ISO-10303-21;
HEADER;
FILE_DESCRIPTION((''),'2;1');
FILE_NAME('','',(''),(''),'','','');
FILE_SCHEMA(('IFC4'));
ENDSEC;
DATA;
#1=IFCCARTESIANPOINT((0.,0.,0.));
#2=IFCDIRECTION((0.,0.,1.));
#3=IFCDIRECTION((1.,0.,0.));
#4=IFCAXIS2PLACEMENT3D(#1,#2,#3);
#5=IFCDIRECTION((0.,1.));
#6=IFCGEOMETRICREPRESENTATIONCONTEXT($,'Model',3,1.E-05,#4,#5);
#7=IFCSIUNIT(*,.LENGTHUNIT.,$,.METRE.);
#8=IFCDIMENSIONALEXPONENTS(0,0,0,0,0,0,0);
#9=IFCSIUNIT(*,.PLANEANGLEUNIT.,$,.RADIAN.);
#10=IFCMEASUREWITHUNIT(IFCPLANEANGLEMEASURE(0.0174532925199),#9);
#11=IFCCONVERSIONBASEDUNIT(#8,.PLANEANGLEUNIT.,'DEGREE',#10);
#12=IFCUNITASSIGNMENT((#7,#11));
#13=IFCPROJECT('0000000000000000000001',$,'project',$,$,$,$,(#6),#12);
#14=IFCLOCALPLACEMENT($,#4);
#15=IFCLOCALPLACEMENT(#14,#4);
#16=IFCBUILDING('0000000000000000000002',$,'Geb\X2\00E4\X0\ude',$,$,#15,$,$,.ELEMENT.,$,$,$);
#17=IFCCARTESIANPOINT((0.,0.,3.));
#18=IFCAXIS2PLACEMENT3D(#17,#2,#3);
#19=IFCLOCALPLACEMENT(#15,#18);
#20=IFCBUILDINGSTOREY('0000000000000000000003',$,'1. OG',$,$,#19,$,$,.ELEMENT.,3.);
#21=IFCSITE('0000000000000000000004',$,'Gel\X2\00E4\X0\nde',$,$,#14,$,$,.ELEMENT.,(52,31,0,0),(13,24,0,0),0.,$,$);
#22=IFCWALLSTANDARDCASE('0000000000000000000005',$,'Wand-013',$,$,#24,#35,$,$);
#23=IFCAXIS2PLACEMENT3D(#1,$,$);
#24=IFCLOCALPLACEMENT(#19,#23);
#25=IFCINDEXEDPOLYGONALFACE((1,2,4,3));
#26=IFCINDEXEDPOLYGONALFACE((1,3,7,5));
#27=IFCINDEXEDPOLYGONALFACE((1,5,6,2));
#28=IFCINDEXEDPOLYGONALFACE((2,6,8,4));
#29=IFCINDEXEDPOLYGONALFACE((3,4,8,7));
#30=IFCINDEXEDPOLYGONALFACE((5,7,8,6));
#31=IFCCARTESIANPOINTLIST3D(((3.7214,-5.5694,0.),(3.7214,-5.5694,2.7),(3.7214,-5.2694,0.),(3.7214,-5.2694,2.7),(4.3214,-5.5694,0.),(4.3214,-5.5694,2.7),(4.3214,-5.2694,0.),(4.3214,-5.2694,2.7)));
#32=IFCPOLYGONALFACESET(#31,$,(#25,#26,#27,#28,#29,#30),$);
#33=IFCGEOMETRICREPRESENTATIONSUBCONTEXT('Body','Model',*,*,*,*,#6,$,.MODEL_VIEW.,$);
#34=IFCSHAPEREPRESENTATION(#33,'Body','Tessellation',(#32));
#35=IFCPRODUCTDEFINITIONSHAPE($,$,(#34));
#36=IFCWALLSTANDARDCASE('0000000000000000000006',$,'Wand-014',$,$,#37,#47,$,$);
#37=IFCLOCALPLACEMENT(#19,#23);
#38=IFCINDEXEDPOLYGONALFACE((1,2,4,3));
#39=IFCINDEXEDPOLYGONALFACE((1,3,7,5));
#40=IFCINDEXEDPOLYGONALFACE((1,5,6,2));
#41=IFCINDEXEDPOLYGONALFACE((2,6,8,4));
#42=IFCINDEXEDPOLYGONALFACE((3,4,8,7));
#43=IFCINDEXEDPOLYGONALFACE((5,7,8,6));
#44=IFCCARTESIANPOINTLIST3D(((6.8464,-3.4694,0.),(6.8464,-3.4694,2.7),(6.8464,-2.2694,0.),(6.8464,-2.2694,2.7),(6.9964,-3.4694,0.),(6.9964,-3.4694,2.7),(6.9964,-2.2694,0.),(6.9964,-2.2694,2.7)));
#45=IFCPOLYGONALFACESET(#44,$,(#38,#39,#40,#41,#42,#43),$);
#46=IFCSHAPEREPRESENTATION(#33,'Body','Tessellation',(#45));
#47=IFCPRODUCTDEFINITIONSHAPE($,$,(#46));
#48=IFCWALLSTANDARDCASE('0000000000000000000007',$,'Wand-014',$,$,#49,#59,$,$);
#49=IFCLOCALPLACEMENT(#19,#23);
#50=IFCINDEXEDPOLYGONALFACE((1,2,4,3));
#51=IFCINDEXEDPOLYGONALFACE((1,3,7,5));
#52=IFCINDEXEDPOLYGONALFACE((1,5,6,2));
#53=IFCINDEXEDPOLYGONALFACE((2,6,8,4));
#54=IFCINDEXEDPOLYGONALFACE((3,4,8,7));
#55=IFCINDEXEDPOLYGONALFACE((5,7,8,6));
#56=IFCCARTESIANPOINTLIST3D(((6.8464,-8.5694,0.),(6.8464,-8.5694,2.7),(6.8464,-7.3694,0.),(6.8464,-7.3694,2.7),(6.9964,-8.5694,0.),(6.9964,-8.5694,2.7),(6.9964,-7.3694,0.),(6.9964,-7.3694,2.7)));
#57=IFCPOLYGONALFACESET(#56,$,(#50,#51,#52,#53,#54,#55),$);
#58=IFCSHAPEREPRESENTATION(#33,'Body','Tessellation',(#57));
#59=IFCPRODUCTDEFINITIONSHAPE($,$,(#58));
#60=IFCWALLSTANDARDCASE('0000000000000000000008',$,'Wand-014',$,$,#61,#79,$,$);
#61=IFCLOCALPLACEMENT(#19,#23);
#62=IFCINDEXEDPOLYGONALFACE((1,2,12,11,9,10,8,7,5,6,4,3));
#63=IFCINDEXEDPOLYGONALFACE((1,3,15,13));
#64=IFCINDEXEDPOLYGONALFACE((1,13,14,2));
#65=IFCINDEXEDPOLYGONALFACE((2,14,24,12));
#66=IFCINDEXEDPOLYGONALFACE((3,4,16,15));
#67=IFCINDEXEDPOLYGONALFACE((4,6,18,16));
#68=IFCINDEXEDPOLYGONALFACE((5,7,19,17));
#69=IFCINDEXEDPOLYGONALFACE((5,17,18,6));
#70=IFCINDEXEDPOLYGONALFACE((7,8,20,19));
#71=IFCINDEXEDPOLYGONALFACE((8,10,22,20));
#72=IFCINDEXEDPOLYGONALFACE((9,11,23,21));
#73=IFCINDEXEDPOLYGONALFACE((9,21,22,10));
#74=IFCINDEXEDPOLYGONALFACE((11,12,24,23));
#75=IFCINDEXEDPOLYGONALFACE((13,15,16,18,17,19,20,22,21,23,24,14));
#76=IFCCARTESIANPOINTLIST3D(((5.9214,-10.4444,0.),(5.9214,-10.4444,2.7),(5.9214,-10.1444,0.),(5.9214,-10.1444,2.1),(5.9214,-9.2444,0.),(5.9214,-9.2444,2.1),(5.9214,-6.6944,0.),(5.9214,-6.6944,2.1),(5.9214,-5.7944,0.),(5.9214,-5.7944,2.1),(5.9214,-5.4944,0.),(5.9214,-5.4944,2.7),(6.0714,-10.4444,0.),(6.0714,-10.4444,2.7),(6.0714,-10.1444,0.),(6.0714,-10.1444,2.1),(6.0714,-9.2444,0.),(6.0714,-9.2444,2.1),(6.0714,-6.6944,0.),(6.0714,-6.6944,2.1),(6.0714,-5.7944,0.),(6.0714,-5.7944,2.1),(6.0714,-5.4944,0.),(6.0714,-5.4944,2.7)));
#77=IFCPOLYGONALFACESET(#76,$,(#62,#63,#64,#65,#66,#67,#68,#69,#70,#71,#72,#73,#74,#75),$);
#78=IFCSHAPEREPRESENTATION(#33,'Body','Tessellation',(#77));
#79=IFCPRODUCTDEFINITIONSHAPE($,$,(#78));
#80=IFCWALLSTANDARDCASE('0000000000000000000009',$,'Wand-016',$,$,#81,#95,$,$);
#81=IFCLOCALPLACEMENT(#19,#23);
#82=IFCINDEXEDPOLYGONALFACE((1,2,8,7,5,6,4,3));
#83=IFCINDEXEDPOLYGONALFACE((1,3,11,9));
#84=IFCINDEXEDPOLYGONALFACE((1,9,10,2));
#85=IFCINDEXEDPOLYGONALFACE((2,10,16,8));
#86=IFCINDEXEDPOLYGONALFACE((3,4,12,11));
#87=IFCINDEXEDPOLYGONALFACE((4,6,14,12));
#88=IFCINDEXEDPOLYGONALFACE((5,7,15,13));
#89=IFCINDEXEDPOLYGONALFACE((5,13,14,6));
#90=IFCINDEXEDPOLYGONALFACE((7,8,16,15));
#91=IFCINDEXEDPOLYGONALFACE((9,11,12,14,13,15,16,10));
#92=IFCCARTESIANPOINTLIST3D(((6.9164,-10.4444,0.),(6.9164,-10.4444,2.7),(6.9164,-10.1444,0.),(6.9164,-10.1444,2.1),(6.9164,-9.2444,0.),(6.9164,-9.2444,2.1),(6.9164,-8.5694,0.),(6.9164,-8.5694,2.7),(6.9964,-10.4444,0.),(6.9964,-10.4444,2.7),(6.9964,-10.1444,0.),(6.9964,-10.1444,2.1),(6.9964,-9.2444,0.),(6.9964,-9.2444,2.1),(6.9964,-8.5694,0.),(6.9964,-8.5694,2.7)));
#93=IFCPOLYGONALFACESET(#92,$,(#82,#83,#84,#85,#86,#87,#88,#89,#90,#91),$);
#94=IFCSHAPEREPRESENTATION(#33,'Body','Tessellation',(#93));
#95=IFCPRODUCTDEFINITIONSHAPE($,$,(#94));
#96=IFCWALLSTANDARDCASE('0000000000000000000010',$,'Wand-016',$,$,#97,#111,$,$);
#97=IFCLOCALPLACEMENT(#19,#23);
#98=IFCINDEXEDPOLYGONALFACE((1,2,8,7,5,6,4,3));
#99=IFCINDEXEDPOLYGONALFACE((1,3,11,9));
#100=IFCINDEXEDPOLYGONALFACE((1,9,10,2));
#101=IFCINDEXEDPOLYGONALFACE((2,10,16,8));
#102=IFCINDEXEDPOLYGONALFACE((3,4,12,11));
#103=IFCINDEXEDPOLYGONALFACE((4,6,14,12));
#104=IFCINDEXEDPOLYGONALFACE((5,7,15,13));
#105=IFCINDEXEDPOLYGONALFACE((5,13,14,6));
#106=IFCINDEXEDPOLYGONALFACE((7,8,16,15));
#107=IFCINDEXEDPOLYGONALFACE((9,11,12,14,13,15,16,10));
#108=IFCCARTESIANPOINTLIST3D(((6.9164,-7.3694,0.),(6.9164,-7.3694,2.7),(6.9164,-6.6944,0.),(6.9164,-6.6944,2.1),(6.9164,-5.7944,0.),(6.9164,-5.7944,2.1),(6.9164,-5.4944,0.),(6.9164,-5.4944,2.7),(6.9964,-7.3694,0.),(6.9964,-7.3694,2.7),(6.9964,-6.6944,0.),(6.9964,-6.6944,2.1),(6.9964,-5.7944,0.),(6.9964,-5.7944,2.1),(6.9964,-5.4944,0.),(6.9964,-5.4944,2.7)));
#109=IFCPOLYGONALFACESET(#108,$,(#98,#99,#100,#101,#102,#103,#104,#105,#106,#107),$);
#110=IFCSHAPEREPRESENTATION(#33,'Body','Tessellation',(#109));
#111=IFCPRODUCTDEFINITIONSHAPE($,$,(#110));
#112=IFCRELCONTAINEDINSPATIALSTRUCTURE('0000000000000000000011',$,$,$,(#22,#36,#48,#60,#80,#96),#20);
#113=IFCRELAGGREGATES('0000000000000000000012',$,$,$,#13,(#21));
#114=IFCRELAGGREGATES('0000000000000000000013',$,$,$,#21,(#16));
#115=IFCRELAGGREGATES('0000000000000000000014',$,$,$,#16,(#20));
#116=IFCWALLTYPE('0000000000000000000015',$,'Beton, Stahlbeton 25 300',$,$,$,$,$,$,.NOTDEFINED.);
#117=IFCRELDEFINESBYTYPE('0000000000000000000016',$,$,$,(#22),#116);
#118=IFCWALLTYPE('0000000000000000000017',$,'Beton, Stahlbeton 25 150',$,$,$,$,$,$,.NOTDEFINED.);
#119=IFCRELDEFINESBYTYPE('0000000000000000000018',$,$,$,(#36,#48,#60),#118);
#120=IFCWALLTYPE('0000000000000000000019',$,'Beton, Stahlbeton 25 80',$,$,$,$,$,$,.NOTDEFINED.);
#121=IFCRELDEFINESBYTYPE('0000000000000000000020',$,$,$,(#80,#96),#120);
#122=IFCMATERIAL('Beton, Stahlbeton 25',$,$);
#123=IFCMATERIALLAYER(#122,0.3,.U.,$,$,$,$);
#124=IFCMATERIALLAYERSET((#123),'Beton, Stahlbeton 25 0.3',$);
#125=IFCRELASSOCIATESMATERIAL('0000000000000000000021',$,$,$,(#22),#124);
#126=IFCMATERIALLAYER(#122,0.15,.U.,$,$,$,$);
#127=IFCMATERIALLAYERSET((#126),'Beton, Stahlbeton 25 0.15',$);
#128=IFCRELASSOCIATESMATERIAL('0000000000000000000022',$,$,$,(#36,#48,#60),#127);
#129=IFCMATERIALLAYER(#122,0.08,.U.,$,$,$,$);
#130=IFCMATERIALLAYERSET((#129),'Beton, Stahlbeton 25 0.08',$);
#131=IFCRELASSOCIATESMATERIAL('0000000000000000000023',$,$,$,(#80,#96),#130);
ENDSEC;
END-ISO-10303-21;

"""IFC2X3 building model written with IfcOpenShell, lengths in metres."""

from ifc_helpers import new_model, entity, si_unit, converted_unit, direction, frame, origin_with_axes, origin_2d_with_axis, place, context, subcontext, project, spatial, polyline, rectangle, outline, extrude, material, layer, layer_set, layer_usage, type_object, element, save


model = new_model("IFC2X3")

# Units and contexts
model_context = context("Model", 3, precision=1e-05, world=origin_with_axes(), true_north=direction((0.0, 1.0)))
body_context = subcontext(model_context, "Body", "Model", "MODEL_VIEW")
ifc_project = project(units=[si_unit("LENGTHUNIT", "METRE"), converted_unit("PLANEANGLEUNIT", "DEGREE", entity("IfcPlaneAngleMeasure", 0.0174532925199), si_unit("PLANEANGLEUNIT", "RADIAN"), dimensions=[0, 0, 0, 0, 0, 0, 0])], contexts=[model_context])

# Site, building, storey
site_placement = place(None, origin_with_axes())
site = spatial("IfcSite", under=ifc_project, at=site_placement, Name="Gelände", CompositionType="ELEMENT", RefLatitude=(52, 31, 0, 0), RefLongitude=(13, 24, 0, 0), RefElevation=0.0)
building_placement = place(site_placement, origin_with_axes())
building = spatial("IfcBuilding", under=site, at=building_placement, Name="Gebäude", CompositionType="ELEMENT")
storey_placement = place(building_placement, frame((0.0, 0.0, 3.0), z_axis=(0.0, 0.0, 1.0), x_axis=(1.0, 0.0, 0.0)))
storey = spatial("IfcBuildingStorey", under=building, at=storey_placement, Name="1. OG", CompositionType="ELEMENT", Elevation=3.0)

# Walls
ifc_material = material(Name="Beton, Stahlbeton 25")
ifc_layer_1 = layer(ifc_material, 0.3, ventilated="UNKNOWN")
ifc_layer_set_1 = layer_set([ifc_layer_1], Name="Beton, Stahlbeton 25 0.3")
ifc_layer_usage_1 = layer_usage(ifc_layer_set_1, "AXIS2", "NEGATIVE", 0.3)
wall_type_1 = type_object("IfcWallType", Name="Beton, Stahlbeton 25 300", PredefinedType="NOTDEFINED")
wall_1_placement = place(storey_placement, frame((3.7214, -5.5694, 0.0), z_axis=(0.0, 0.0, 1.0), x_axis=(1.0, 0.0, 0.0)))
element("IfcWallStandardCase", 1, at=wall_1_placement, inside=storey, type_object=wall_type_1, material=ifc_layer_usage_1, Name="Wand-013", context=body_context, shape_type="SweptSolid", body=[
    extrude(outline(polyline([(0.0, 0.0), (0.6, 0.0), (0.6, 0.3), (0.0, 0.3), (0.0, 0.0)])), origin_with_axes(), (0.0, 0.0, 1.0), 2.7),
])
ifc_layer_2 = layer(ifc_material, 0.15, ventilated="UNKNOWN")
ifc_layer_set_2 = layer_set([ifc_layer_2], Name="Beton, Stahlbeton 25 0.15")
ifc_layer_usage_2 = layer_usage(ifc_layer_set_2, "AXIS2", "POSITIVE", 0.0)
wall_type_2 = type_object("IfcWallType", Name="Beton, Stahlbeton 25 150", PredefinedType="NOTDEFINED")
wall_2_placement = place(storey_placement, frame((6.9964, -3.4694, 0.0), z_axis=(0.0, 0.0, 1.0), x_axis=(0.0, 1.0, 0.0)))
element("IfcWallStandardCase", 2, at=wall_2_placement, inside=storey, type_object=wall_type_2, material=ifc_layer_usage_2, Name="Wand-014", context=body_context, shape_type="SweptSolid", body=[
    extrude(outline(polyline([(0.0, 0.0), (1.2, 0.0), (1.2, 0.15), (0.0, 0.15), (0.0, 0.0)])), origin_with_axes(), (0.0, 0.0, 1.0), 2.7),
])
ifc_layer_usage_3 = layer_usage(ifc_layer_set_2, "AXIS2", "POSITIVE", 0.0)
wall_3_placement = place(storey_placement, frame((6.9964, -8.5694, 0.0), z_axis=(0.0, 0.0, 1.0), x_axis=(0.0, 1.0, 0.0)))
element("IfcWallStandardCase", 3, at=wall_3_placement, inside=storey, type_object=wall_type_2, material=ifc_layer_usage_3, Name="Wand-014", context=body_context, shape_type="SweptSolid", body=[
    extrude(outline(polyline([(0.0, 0.0), (1.2, 0.0), (1.2, 0.15), (0.0, 0.15), (0.0, 0.0)])), origin_with_axes(), (0.0, 0.0, 1.0), 2.7),
])

# Wall, openings
ifc_layer_usage_4 = layer_usage(ifc_layer_set_2, "AXIS2", "NEGATIVE", 0.0)
wall_4_placement = place(storey_placement, frame((5.9214, -10.4444, 0.0), z_axis=(0.0, 0.0, 1.0), x_axis=(0.0, 1.0, 0.0)))
wall_4 = element("IfcWallStandardCase", 4, at=wall_4_placement, inside=storey, type_object=wall_type_2, material=ifc_layer_usage_4, Name="Wand-014", context=body_context, shape_type="SweptSolid", body=[
    extrude(outline(polyline([(0.0, -0.15), (4.95, -0.15), (4.95, 0.0), (0.0, 0.0), (0.0, -0.15)])), origin_with_axes(), (0.0, 0.0, 1.0), 2.7),
])
opening_1_placement = place(wall_4_placement, frame((4.2, 0.0, 0.0), z_axis=(0.0, 0.0, 1.0), x_axis=(1.0, 0.0, 0.0)))
element("IfcOpeningElement", 5, at=opening_1_placement, cuts=wall_4, context=body_context, shape_type="SweptSolid", body=[
    extrude(rectangle(XDim=0.9, YDim=2.1, at=origin_2d_with_axis()), frame((0.0, 0.15, 1.05), z_axis=(0.0, -1.0, 0.0), x_axis=(1.0, 0.0, 0.0)), (0.0, 0.0, 1.0), 0.15),
    extrude(rectangle(XDim=0.9, YDim=2.1, at=origin_2d_with_axis()), frame((0.0, -0.15, 1.05), z_axis=(0.0, 1.0, 0.0), x_axis=(1.0, 0.0, 0.0)), (0.0, 0.0, 1.0), 0.15),
])
opening_2_placement = place(wall_4_placement, frame((0.75, 0.0, 0.0), z_axis=(0.0, 0.0, 1.0), x_axis=(1.0, 0.0, 0.0)))
element("IfcOpeningElement", 6, at=opening_2_placement, cuts=wall_4, context=body_context, shape_type="SweptSolid", body=[
    extrude(rectangle(XDim=0.9, YDim=2.1, at=origin_2d_with_axis()), frame((0.0, 0.15, 1.05), z_axis=(0.0, -1.0, 0.0), x_axis=(1.0, 0.0, 0.0)), (0.0, 0.0, 1.0), 0.15),
    extrude(rectangle(XDim=0.9, YDim=2.1, at=origin_2d_with_axis()), frame((0.0, -0.15, 1.05), z_axis=(0.0, 1.0, 0.0), x_axis=(1.0, 0.0, 0.0)), (0.0, 0.0, 1.0), 0.15),
])

# Walls, openings
ifc_layer_3 = layer(ifc_material, 0.08, ventilated="UNKNOWN")
ifc_layer_set_3 = layer_set([ifc_layer_3], Name="Beton, Stahlbeton 25 0.08")
wall_type_3 = type_object("IfcWallType", Name="Beton, Stahlbeton 25 80", PredefinedType="NOTDEFINED")
ifc_layer_usage_5 = layer_usage(ifc_layer_set_3, "AXIS2", "POSITIVE", 0.0)
wall_5_placement = place(storey_placement, frame((6.9164, -8.5694, 0.0), z_axis=(0.0, 0.0, 1.0), x_axis=(0.0, -1.0, 0.0)))
wall_5 = element("IfcWallStandardCase", 7, at=wall_5_placement, inside=storey, type_object=wall_type_3, material=ifc_layer_usage_5, Name="Wand-016", context=body_context, shape_type="SweptSolid", body=[
    extrude(outline(polyline([(0.0, 0.0), (1.875, 0.0), (1.875, 0.08), (0.0, 0.08), (0.0, 0.0)])), origin_with_axes(), (0.0, 0.0, 1.0), 2.7),
])
opening_3_placement = place(wall_5_placement, frame((1.125, 0.0, 0.0), z_axis=(0.0, 0.0, 1.0), x_axis=(1.0, 0.0, 0.0)))
element("IfcOpeningElement", 8, at=opening_3_placement, cuts=wall_5, context=body_context, shape_type="SweptSolid", body=[
    extrude(rectangle(XDim=0.9, YDim=2.1, at=origin_2d_with_axis()), frame((0.0, -0.08, 1.05), z_axis=(0.0, 1.0, 0.0), x_axis=(1.0, 0.0, 0.0)), (0.0, 0.0, 1.0), 0.08),
    extrude(rectangle(XDim=0.9, YDim=2.1, at=origin_2d_with_axis()), frame((0.0, 0.08, 1.05), z_axis=(0.0, -1.0, 0.0), x_axis=(1.0, 0.0, 0.0)), (0.0, 0.0, 1.0), 0.08),
])
ifc_layer_usage_6 = layer_usage(ifc_layer_set_3, "AXIS2", "NEGATIVE", 0.0)
wall_6_placement = place(storey_placement, frame((6.9164, -7.3694, 0.0), z_axis=(0.0, 0.0, 1.0), x_axis=(0.0, 1.0, 0.0)))
wall_6 = element("IfcWallStandardCase", 9, at=wall_6_placement, inside=storey, type_object=wall_type_3, material=ifc_layer_usage_6, Name="Wand-016", context=body_context, shape_type="SweptSolid", body=[
    extrude(outline(polyline([(0.0, -0.08), (1.875, -0.08), (1.875, 0.0), (0.0, 0.0), (0.0, -0.08)])), origin_with_axes(), (0.0, 0.0, 1.0), 2.7),
])
opening_4_placement = place(wall_6_placement, frame((1.125, 0.0, 0.0), z_axis=(0.0, 0.0, 1.0), x_axis=(1.0, 0.0, 0.0)))
element("IfcOpeningElement", 10, at=opening_4_placement, cuts=wall_6, context=body_context, shape_type="SweptSolid", body=[
    extrude(rectangle(XDim=0.9, YDim=2.1, at=origin_2d_with_axis()), frame((0.0, 0.08, 1.05), z_axis=(0.0, -1.0, 0.0), x_axis=(1.0, 0.0, 0.0)), (0.0, 0.0, 1.0), 0.08),
    extrude(rectangle(XDim=0.9, YDim=2.1, at=origin_2d_with_axis()), frame((0.0, -0.08, 1.05), z_axis=(0.0, 1.0, 0.0), x_axis=(1.0, 0.0, 0.0)), (0.0, 0.0, 1.0), 0.08),
])

save(model, "model.ifc")
